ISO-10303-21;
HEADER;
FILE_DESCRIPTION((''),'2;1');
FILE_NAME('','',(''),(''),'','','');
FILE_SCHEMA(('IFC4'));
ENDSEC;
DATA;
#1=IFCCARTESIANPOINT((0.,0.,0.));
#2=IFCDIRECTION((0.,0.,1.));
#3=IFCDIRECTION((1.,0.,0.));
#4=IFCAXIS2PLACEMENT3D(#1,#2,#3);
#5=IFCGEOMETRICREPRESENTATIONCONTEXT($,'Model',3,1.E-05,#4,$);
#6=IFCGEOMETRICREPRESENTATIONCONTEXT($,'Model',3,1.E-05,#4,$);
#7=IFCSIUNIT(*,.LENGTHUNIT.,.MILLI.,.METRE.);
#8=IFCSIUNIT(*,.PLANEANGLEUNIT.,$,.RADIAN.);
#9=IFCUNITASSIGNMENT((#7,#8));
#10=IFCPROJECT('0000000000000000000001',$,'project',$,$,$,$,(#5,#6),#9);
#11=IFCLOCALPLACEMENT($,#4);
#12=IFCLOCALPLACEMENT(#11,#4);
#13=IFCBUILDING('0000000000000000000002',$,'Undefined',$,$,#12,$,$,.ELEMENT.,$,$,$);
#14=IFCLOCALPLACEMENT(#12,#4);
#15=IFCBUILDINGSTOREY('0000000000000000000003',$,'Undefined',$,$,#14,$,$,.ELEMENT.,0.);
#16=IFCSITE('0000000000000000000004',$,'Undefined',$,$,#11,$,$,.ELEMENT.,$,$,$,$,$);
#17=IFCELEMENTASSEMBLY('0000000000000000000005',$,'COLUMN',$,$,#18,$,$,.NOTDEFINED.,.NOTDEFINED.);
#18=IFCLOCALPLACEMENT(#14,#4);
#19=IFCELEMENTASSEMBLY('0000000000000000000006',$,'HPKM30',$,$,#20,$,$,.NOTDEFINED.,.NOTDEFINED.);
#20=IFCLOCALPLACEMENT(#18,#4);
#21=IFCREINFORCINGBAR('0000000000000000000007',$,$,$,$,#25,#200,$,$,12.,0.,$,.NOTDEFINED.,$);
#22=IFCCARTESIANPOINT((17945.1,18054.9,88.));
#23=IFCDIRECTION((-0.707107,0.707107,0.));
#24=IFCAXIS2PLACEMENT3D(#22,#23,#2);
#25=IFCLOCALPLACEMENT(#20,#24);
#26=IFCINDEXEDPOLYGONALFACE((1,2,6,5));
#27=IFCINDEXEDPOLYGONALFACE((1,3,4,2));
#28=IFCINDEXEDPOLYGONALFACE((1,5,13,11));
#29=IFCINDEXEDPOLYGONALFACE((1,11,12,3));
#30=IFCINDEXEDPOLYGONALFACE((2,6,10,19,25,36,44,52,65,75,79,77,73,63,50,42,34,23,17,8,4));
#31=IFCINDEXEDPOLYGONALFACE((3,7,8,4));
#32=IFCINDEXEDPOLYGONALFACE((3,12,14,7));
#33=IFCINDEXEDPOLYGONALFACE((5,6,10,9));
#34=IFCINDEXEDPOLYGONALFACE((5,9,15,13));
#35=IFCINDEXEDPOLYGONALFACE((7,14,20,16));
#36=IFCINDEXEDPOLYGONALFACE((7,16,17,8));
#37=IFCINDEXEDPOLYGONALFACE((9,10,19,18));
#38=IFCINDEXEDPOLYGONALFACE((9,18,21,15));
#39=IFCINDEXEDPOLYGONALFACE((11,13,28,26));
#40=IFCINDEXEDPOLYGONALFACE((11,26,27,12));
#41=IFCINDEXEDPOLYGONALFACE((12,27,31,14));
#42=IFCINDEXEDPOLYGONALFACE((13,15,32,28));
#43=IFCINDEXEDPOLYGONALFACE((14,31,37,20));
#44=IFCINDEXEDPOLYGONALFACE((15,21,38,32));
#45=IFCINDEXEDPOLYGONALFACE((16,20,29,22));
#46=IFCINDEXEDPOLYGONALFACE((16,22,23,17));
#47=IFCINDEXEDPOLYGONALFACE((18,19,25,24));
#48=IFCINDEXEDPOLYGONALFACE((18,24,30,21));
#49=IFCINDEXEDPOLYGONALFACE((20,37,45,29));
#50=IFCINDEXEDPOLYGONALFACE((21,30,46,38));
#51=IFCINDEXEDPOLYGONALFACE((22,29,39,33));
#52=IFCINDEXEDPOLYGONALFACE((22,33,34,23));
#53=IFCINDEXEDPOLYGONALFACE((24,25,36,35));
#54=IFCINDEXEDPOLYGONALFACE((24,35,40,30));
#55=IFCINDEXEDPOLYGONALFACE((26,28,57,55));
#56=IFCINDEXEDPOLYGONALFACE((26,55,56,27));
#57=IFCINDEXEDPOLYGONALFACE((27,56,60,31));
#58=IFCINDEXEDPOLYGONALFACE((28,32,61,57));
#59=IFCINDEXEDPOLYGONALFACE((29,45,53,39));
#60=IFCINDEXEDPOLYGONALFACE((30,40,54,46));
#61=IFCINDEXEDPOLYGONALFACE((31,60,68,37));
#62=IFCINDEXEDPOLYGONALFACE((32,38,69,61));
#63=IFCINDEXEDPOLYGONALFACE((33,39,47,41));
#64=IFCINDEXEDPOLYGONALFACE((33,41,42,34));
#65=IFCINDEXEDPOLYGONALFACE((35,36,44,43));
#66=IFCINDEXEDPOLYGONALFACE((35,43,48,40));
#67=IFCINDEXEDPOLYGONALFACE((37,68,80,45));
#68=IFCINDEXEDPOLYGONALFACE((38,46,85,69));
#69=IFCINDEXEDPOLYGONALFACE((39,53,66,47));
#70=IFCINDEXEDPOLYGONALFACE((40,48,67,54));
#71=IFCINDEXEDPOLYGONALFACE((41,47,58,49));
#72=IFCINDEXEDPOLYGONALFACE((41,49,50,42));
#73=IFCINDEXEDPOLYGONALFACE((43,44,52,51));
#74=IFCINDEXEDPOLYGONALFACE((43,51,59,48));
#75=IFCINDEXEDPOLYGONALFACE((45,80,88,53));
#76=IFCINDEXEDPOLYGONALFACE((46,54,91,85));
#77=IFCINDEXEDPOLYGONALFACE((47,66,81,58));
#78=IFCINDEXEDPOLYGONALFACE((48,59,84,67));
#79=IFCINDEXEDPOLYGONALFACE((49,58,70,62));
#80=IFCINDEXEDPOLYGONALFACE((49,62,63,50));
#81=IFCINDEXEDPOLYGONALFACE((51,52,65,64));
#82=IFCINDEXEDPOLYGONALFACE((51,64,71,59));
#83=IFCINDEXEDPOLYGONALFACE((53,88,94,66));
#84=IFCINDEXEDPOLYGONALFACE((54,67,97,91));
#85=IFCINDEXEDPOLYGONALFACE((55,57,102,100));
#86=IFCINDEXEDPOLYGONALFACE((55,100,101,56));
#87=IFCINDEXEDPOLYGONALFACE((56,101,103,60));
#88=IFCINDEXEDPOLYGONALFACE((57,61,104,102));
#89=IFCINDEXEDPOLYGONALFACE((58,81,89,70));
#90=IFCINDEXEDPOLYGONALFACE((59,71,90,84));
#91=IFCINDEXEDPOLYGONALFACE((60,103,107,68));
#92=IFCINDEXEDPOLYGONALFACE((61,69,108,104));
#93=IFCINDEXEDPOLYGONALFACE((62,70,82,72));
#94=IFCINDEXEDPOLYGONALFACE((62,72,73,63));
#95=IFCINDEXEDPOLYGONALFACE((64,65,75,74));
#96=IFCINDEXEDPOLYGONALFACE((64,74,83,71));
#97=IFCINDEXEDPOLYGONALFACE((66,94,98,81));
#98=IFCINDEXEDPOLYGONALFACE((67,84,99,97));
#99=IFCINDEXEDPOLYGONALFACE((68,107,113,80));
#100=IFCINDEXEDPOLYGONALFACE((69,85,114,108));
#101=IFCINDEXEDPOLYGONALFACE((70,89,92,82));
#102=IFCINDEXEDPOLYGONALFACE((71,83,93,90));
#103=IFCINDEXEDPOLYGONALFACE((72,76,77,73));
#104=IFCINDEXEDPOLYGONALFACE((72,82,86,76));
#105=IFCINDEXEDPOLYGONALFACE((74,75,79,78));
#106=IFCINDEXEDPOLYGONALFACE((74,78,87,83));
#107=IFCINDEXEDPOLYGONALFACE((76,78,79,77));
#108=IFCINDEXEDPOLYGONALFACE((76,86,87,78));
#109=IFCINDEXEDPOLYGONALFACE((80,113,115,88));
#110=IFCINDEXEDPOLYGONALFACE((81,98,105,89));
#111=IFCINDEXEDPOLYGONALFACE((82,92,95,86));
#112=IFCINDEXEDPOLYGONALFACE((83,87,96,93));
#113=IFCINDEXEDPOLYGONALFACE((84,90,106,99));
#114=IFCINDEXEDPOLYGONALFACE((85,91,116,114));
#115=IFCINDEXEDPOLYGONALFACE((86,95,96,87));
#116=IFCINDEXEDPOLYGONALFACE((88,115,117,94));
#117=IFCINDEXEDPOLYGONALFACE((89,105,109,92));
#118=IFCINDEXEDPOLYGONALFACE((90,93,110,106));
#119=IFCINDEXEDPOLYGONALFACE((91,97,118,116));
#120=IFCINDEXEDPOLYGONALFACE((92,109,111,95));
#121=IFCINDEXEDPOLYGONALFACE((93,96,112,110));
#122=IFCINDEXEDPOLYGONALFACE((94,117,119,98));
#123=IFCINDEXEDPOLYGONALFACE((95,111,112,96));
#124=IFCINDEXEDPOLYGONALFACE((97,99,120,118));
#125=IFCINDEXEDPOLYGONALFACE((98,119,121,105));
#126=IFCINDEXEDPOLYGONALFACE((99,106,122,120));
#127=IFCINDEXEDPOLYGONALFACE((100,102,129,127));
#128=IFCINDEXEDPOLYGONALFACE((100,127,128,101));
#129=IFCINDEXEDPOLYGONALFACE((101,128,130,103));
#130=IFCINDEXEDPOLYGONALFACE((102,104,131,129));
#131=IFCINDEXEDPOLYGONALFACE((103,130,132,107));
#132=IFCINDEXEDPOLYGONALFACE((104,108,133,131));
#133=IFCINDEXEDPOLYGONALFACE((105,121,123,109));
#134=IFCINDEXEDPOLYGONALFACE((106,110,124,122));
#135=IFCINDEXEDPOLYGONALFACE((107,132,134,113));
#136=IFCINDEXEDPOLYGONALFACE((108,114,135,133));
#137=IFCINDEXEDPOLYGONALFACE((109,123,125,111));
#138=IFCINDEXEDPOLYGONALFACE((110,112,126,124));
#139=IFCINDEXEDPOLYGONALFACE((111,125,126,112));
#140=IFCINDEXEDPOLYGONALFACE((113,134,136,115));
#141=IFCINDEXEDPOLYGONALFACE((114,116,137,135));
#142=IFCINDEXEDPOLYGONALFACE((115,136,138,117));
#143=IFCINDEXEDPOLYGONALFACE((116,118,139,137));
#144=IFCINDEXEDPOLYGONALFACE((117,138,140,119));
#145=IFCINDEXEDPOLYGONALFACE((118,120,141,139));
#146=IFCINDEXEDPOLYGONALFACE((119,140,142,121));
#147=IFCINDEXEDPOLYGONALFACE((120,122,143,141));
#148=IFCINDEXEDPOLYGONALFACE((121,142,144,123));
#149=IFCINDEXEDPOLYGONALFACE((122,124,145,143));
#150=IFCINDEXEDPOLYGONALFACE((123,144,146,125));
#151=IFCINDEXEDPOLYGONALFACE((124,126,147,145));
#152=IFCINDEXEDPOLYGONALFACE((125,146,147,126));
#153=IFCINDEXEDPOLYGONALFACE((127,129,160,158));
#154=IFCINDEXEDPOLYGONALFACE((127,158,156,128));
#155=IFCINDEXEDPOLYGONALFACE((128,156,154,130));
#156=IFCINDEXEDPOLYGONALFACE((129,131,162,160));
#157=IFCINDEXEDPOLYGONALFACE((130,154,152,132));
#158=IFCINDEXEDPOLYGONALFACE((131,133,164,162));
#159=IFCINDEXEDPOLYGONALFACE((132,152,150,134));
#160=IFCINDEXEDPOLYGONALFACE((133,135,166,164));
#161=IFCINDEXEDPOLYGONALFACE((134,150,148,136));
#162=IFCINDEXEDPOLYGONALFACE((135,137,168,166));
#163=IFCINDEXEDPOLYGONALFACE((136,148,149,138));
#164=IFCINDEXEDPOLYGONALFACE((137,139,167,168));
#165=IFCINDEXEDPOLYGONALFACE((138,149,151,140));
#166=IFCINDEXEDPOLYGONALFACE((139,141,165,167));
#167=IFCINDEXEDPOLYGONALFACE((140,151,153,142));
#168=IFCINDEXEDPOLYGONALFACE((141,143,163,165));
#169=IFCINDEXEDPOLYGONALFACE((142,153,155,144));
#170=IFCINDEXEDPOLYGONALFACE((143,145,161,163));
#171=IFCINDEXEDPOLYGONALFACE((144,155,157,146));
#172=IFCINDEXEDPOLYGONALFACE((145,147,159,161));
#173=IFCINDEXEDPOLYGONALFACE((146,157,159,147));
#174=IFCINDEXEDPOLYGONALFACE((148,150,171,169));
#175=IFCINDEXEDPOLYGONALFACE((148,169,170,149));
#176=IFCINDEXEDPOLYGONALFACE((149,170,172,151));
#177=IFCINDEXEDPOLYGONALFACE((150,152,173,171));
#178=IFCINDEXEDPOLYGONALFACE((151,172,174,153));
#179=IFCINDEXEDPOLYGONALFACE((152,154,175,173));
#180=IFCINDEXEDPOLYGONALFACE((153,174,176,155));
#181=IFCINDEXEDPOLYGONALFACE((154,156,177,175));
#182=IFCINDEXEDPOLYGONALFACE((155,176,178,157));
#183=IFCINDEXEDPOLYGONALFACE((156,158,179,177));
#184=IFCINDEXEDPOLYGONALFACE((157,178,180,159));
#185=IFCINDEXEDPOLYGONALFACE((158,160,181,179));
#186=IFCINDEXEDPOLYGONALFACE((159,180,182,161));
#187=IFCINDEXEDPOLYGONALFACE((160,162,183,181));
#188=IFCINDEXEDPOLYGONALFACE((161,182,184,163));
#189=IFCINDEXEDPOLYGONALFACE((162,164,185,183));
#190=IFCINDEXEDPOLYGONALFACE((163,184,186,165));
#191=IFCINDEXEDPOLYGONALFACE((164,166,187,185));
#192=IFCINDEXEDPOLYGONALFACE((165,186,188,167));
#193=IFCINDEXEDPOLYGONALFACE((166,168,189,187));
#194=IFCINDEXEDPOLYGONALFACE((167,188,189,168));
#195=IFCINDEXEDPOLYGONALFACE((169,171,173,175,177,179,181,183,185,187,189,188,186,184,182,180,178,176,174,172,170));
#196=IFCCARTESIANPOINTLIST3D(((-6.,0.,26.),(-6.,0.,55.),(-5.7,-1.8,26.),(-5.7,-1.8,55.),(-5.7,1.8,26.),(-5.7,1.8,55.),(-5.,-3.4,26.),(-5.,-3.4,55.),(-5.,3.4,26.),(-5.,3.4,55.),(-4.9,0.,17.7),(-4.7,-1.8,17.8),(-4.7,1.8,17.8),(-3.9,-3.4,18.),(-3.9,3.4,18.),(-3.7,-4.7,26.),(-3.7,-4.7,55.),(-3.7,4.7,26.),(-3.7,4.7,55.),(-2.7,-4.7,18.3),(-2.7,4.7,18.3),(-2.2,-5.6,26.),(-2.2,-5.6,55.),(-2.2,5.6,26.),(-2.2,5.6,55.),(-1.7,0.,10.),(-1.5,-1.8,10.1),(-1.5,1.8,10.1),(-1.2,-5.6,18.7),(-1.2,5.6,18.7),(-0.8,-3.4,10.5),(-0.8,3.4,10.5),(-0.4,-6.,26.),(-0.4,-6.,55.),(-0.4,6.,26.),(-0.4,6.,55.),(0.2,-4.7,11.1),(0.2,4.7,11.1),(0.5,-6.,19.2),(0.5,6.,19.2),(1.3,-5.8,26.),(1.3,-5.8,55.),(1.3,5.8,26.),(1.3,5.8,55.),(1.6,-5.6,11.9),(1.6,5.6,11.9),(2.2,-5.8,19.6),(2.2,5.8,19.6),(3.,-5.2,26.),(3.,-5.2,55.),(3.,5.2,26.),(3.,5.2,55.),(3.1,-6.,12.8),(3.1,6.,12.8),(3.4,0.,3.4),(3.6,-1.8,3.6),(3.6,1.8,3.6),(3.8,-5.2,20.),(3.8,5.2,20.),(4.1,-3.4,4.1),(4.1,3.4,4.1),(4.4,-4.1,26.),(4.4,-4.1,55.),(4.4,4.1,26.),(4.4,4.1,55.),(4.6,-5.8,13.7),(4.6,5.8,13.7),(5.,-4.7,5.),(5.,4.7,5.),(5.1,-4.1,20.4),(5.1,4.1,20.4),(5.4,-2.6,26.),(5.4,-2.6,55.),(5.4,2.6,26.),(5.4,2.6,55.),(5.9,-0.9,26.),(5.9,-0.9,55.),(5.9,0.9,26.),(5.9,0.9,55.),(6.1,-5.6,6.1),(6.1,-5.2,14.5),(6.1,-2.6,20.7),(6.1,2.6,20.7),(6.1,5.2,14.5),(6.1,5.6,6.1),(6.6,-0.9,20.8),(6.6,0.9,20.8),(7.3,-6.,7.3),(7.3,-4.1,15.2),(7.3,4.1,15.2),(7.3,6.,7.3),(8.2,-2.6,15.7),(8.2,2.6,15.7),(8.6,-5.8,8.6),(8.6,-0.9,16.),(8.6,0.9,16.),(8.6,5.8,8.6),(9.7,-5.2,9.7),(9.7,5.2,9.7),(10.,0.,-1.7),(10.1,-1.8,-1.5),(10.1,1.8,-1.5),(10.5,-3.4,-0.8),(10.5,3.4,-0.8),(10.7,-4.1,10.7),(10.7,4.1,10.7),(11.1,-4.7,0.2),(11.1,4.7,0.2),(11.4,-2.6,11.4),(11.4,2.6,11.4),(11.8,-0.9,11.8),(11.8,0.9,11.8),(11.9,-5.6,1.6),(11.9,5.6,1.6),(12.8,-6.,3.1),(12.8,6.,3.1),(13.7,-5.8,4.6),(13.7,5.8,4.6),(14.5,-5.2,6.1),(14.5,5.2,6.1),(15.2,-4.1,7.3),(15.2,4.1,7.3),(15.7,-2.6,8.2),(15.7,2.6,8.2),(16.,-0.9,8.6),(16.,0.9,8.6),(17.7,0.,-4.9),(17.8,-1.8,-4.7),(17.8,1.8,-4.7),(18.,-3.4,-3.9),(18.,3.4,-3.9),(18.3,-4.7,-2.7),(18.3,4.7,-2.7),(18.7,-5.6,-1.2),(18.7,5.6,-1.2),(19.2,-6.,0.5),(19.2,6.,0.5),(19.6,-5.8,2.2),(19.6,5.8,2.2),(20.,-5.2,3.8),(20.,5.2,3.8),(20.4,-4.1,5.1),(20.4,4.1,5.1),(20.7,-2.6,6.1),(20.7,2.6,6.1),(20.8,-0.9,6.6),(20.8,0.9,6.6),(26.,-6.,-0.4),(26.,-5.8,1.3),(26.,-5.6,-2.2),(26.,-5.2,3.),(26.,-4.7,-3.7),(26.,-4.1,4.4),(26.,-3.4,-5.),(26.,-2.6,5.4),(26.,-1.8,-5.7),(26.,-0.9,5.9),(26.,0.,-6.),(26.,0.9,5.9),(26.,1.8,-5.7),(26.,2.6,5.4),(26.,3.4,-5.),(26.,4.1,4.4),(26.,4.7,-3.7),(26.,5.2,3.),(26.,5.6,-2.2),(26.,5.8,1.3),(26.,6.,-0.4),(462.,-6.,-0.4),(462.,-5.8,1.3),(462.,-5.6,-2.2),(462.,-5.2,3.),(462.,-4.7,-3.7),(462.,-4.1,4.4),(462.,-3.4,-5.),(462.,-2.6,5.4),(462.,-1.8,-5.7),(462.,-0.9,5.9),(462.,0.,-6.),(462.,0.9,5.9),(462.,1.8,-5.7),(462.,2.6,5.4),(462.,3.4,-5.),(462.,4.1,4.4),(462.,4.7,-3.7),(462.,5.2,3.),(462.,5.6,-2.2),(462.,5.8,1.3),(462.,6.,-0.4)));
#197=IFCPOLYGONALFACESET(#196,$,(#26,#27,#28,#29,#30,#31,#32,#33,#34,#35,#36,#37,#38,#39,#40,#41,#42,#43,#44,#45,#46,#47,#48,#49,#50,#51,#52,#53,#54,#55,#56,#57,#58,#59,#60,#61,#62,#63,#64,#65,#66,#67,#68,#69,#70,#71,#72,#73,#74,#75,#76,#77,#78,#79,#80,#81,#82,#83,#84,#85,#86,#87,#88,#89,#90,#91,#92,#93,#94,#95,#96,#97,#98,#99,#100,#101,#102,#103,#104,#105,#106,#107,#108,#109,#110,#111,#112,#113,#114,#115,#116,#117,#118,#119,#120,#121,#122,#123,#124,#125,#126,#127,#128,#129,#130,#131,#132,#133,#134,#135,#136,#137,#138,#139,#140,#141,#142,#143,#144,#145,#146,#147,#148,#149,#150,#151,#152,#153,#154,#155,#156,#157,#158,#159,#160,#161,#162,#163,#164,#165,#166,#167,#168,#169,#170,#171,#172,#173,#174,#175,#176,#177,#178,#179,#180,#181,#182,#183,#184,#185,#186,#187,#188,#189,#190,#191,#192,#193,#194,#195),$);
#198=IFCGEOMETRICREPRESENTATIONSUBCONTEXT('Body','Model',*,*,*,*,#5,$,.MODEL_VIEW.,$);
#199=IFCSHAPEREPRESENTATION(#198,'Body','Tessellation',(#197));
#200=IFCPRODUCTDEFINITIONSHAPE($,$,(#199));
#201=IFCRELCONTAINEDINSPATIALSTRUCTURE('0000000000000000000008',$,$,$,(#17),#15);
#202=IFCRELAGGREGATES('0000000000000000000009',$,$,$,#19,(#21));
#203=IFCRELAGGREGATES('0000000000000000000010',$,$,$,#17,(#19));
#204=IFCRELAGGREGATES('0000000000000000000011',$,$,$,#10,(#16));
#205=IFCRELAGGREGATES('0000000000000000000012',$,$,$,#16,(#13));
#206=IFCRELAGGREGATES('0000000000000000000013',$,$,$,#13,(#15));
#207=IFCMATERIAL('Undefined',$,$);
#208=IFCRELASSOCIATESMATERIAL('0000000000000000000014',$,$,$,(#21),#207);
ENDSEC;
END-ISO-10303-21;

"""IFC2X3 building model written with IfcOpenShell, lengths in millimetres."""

from ifc_helpers import new_model, entity, si_unit, frame, origin_with_axes, place, context, subcontext, project, spatial, source, transform, mapped, material, element, aggregate, save


model = new_model("IFC2X3")

# Units and contexts
model_context_1 = context("Model", 3, precision=1e-05, world=origin_with_axes())
model_context_2 = context("Model", 3, precision=1e-05, world=origin_with_axes())
body_context = subcontext(model_context_1, "Body", "Model", "MODEL_VIEW")
ifc_project = project(units=[si_unit("LENGTHUNIT", "METRE", prefix="MILLI"), si_unit("PLANEANGLEUNIT", "RADIAN")], contexts=[model_context_1, model_context_2])

# Site, building, storey
site_placement = place(None, origin_with_axes())
site = spatial("IfcSite", under=ifc_project, at=site_placement, Name="Undefined", CompositionType="ELEMENT")
building_placement = place(site_placement, origin_with_axes())
building = spatial("IfcBuilding", under=site, at=building_placement, Name="Undefined", CompositionType="ELEMENT")
storey_placement = place(building_placement, origin_with_axes())
storey = spatial("IfcBuildingStorey", under=building, at=storey_placement, Name="Undefined", CompositionType="ELEMENT", Elevation=0.0)

# Element assembly
assembly_1_placement = place(storey_placement, origin_with_axes())
assembly_1 = element("IfcElementAssembly", 1, at=assembly_1_placement, inside=storey, Name="COLUMN", AssemblyPlace="NOTDEFINED", PredefinedType="NOTDEFINED")

# Element assembly
assembly_2_placement = place(assembly_1_placement, origin_with_axes())
assembly_2 = element("IfcElementAssembly", 2, at=assembly_2_placement, Name="HPKM30", AssemblyPlace="NOTDEFINED", PredefinedType="NOTDEFINED")

# Reinforcing bar
ifc_material_1 = material(Name="Undefined")
shared_shape_1 = source(origin_with_axes(), body_context, "Body", "AdvancedSweptSolid", [
    entity("IfcSweptDiskSolid", entity("IfcCompositeCurve", [entity("IfcCompositeCurveSegment", "CONTINUOUS", True, entity("IfcTrimmedCurve", entity("IfcLine", entity("IfcCartesianPoint", [0.0, 0.0, 0.0]), entity("IfcVector", entity("IfcDirection", [0.0, 0.0, -1.0]), 1.0)), [entity("IfcParameterValue", 0.0)], [entity("IfcParameterValue", 29.0)], True, "PARAMETER")), entity("IfcCompositeCurveSegment", "CONTINUOUS", True, entity("IfcTrimmedCurve", entity("IfcCircle", entity("IfcAxis2Placement3D", entity("IfcCartesianPoint", [26.0, 0.0, -29.0]), entity("IfcDirection", [0.0, -1.0, 0.0]), entity("IfcDirection", [-1.0, 0.0, 0.0])), 26.0), [entity("IfcParameterValue", 0.0)], [entity("IfcParameterValue", 1.570796)], True, "PARAMETER")), entity("IfcCompositeCurveSegment", "DISCONTINUOUS", True, entity("IfcTrimmedCurve", entity("IfcLine", entity("IfcCartesianPoint", [26.0, 0.0, -55.0]), entity("IfcVector", entity("IfcDirection", [1.0, 0.0, 0.0]), 1.0)), [entity("IfcParameterValue", 0.0)], [entity("IfcParameterValue", 436.0)], True, "PARAMETER"))], False), 6.0, None, 0.0, 466.6),
])
reinforcing_bar_1_placement = place(assembly_2_placement, frame((17945.1, 18054.9, 88.0), z_axis=(-0.707107, 0.707107, 0.0), x_axis=(0.0, 0.0, 1.0)))
reinforcing_bar_1 = element("IfcReinforcingBar", 3, at=reinforcing_bar_1_placement, material=ifc_material_1, BarRole="NOTDEFINED", CrossSectionArea=0.0, NominalDiameter=12.0, context=body_context, shape_type="MappedRepresentation", body=[
    mapped(shared_shape_1, transform((0.0, 0.0, 55.0))),
])
aggregate(assembly_2, [reinforcing_bar_1])

aggregate(assembly_1, [assembly_2])

save(model, "model.ifc")
